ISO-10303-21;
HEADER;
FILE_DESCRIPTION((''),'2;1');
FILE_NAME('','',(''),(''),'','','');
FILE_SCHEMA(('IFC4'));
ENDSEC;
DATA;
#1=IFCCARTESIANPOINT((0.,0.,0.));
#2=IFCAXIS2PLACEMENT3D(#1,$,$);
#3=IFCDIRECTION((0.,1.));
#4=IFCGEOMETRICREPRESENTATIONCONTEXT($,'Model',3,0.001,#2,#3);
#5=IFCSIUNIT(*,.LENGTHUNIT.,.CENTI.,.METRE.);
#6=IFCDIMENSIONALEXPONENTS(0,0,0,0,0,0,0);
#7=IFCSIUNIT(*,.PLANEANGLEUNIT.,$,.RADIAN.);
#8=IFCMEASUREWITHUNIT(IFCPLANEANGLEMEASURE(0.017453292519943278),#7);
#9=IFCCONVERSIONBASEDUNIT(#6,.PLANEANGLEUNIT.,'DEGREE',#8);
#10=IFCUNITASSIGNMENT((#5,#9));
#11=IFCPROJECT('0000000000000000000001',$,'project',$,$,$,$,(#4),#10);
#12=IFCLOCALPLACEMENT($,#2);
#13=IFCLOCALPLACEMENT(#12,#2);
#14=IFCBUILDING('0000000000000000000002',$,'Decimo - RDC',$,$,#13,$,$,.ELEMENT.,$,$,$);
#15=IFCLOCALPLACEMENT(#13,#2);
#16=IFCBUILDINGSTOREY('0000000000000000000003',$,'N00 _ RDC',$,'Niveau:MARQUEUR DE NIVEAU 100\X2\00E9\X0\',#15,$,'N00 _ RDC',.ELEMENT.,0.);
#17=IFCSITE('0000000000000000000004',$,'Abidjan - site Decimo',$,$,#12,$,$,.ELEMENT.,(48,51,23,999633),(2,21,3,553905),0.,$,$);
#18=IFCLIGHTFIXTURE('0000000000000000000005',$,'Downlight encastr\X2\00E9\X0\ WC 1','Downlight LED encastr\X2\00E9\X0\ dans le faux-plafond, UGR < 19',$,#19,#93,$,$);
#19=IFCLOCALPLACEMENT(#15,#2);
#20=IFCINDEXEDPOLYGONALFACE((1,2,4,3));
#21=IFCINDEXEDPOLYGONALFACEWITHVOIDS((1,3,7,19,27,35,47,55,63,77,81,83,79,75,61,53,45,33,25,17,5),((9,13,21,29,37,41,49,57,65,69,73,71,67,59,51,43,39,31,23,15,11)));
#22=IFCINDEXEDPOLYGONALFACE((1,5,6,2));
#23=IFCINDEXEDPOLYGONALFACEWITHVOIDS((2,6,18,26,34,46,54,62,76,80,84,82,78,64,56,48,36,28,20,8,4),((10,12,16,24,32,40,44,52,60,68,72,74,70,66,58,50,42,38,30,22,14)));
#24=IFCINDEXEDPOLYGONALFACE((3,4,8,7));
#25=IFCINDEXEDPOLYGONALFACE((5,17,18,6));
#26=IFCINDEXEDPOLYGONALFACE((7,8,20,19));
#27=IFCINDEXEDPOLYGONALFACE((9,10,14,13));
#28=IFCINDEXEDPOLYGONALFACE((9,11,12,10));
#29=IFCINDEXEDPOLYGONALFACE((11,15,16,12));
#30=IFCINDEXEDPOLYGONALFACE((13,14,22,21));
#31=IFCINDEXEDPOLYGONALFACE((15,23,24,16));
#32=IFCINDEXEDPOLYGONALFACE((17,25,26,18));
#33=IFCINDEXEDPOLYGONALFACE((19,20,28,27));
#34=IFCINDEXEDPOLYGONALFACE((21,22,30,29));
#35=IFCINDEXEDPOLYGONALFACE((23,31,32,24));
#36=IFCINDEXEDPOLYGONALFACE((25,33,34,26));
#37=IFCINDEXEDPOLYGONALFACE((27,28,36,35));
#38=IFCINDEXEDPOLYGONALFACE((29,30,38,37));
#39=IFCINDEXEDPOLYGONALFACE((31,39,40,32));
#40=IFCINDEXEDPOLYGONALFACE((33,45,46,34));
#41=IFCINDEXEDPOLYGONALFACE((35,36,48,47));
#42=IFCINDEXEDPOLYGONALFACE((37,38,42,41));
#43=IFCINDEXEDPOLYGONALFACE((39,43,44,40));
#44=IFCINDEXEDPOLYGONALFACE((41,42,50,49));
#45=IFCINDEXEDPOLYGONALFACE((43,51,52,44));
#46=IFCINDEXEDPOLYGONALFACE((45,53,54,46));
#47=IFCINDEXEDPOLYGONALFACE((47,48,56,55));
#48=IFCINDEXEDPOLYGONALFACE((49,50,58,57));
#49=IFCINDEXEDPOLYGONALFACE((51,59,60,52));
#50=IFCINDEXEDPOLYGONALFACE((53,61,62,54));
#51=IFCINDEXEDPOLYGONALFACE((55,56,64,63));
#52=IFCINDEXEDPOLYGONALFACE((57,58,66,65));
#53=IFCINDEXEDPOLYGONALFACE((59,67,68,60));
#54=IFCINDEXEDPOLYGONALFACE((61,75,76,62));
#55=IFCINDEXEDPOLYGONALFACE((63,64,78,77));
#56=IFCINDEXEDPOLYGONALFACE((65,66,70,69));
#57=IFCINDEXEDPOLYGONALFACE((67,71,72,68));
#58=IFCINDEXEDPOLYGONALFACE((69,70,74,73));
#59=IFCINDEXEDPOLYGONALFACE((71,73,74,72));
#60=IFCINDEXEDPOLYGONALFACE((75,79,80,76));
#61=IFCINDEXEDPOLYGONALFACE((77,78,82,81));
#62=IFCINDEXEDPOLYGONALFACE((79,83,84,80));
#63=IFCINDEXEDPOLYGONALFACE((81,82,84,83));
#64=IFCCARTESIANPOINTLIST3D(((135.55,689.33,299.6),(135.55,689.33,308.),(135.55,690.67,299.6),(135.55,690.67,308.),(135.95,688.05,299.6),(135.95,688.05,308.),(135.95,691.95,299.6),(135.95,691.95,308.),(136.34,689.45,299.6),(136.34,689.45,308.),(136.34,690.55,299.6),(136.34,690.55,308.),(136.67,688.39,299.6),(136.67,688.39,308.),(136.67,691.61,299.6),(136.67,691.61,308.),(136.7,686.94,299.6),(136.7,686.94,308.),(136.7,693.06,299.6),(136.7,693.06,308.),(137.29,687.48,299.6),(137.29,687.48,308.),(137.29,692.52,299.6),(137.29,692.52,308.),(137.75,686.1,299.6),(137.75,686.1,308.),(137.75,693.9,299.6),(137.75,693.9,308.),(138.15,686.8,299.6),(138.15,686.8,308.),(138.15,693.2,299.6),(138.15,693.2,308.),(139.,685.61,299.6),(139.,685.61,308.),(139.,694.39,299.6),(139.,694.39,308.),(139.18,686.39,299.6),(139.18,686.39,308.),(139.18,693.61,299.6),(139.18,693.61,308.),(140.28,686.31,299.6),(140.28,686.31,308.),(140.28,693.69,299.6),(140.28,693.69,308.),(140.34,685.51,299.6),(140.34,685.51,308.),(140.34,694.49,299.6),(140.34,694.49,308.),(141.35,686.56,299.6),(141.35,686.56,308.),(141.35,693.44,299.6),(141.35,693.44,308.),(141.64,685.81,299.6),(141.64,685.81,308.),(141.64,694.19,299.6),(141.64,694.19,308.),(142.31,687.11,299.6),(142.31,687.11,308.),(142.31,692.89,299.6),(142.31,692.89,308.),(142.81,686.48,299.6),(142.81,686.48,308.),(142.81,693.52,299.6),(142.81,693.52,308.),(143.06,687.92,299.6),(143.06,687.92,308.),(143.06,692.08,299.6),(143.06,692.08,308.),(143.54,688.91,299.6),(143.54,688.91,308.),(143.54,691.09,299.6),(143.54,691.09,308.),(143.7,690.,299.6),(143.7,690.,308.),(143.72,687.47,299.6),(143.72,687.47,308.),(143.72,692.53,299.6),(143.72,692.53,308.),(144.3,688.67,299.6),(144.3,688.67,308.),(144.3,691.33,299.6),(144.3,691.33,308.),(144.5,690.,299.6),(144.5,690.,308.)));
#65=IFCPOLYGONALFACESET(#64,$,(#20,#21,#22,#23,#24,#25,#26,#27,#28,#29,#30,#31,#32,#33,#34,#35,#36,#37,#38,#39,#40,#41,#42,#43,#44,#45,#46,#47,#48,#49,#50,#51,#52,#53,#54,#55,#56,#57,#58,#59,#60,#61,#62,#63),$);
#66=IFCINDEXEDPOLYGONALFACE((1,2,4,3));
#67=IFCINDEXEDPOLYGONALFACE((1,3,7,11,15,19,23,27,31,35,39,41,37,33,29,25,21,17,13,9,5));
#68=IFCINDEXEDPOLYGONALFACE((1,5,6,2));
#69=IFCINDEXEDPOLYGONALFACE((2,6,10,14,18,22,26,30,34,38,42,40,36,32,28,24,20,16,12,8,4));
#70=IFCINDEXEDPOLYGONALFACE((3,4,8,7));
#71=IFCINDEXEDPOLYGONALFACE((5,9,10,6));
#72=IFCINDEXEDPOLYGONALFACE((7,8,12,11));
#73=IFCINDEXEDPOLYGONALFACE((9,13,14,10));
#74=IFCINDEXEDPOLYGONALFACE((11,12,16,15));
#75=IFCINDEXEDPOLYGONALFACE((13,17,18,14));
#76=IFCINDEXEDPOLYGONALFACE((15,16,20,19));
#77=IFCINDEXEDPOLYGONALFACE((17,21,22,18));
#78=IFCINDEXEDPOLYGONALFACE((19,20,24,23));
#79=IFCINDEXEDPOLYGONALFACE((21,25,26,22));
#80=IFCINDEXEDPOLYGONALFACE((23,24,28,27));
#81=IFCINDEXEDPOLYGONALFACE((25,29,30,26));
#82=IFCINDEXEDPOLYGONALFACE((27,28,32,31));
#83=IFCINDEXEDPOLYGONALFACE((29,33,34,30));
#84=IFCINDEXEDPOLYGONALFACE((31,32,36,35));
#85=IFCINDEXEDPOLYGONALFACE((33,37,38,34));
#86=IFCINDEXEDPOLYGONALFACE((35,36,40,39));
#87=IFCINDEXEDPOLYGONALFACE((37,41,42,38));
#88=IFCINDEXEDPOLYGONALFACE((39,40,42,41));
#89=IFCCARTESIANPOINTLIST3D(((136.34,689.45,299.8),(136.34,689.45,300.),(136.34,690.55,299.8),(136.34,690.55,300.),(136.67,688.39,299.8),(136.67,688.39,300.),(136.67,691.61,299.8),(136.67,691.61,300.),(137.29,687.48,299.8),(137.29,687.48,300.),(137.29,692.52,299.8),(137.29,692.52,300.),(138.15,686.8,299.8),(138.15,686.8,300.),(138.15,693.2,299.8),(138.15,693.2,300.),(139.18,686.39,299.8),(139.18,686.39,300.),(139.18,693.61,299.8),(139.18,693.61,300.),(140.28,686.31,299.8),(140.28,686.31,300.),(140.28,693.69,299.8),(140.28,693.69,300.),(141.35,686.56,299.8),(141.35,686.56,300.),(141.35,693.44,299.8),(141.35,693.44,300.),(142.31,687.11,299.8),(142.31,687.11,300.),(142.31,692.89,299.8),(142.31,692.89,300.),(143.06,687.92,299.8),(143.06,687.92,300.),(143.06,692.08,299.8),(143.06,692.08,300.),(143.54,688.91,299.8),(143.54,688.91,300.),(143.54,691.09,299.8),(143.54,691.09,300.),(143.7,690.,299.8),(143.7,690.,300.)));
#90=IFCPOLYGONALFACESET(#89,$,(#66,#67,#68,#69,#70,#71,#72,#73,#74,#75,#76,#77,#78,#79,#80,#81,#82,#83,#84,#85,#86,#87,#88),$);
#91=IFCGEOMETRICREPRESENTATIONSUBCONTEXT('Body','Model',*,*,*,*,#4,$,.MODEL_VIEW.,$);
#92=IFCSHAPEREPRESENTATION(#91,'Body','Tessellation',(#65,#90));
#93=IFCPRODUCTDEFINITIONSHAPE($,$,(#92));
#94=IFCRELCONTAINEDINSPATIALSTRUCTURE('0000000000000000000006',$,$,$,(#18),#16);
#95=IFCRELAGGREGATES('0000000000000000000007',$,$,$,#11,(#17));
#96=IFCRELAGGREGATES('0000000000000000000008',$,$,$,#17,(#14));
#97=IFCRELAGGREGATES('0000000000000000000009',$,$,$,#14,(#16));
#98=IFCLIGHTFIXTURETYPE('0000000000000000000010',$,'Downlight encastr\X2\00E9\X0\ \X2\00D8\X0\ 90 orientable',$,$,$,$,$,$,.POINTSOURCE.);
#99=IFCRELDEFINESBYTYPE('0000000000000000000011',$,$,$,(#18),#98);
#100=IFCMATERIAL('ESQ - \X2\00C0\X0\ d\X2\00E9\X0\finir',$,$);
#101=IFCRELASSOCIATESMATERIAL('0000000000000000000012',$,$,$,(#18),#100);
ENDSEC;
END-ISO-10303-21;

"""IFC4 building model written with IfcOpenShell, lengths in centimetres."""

from ifc_helpers import new_model, entity, si_unit, converted_unit, direction, frame, frame_2d, origin, origin_with_axes, place, context, subcontext, project, spatial, circle, hollow_circle, extrude, material, type_object, element, save


model = new_model("IFC4")

# Units and contexts
model_context = context("Model", 3, precision=0.001, world=origin(), true_north=direction((0.0, 1.0)))
body_context = subcontext(model_context, "Body", "Model", "MODEL_VIEW")
ifc_project = project(units=[si_unit("LENGTHUNIT", "METRE", prefix="CENTI"), converted_unit("PLANEANGLEUNIT", "DEGREE", entity("IfcPlaneAngleMeasure", 0.017453292519943278), si_unit("PLANEANGLEUNIT", "RADIAN"), dimensions=[0, 0, 0, 0, 0, 0, 0])], contexts=[model_context])

# Site, building, storey
site_placement = place(None, origin())
site = spatial("IfcSite", under=ifc_project, at=site_placement, Name="Abidjan - site Decimo", CompositionType="ELEMENT", RefLatitude=(48, 51, 23, 999633), RefLongitude=(2, 21, 3, 553905), RefElevation=0.0)
building_placement = place(site_placement, origin())
building = spatial("IfcBuilding", under=site, at=building_placement, Name="Decimo - RDC", CompositionType="ELEMENT")
storey_placement = place(building_placement, origin())
storey = spatial("IfcBuildingStorey", under=building, at=storey_placement, Name="N00 _ RDC", ObjectType="Niveau:MARQUEUR DE NIVEAU 100é", LongName="N00 _ RDC", CompositionType="ELEMENT", Elevation=0.0)

# Light fixture
ifc_material_1 = material(Name="ESQ - À définir")
light_fixture_type_1 = type_object("IfcLightFixtureType", Name="Downlight encastré Ø 90 orientable", PredefinedType="POINTSOURCE")
light_fixture_1_placement = place(storey_placement, origin_with_axes())
element("IfcLightFixture", 1, at=light_fixture_1_placement, inside=storey, type_object=light_fixture_type_1, material=ifc_material_1, Name="Downlight encastré WC 1", Description="Downlight LED encastré dans le faux-plafond, UGR < 19", context=body_context, shape_type="SweptSolid", body=[
    extrude(hollow_circle(Radius=4.5, WallThickness=0.8, at=frame_2d((140.0, 690.0))), frame((0.0, 0.0, 299.6)), (0.0, 0.0, 1.0), 8.4),
    extrude(circle(Radius=3.7, at=frame_2d((140.0, 690.0))), frame((0.0, 0.0, 299.8)), (0.0, 0.0, 1.0), 0.2),
])

save(model, "model.ifc")
